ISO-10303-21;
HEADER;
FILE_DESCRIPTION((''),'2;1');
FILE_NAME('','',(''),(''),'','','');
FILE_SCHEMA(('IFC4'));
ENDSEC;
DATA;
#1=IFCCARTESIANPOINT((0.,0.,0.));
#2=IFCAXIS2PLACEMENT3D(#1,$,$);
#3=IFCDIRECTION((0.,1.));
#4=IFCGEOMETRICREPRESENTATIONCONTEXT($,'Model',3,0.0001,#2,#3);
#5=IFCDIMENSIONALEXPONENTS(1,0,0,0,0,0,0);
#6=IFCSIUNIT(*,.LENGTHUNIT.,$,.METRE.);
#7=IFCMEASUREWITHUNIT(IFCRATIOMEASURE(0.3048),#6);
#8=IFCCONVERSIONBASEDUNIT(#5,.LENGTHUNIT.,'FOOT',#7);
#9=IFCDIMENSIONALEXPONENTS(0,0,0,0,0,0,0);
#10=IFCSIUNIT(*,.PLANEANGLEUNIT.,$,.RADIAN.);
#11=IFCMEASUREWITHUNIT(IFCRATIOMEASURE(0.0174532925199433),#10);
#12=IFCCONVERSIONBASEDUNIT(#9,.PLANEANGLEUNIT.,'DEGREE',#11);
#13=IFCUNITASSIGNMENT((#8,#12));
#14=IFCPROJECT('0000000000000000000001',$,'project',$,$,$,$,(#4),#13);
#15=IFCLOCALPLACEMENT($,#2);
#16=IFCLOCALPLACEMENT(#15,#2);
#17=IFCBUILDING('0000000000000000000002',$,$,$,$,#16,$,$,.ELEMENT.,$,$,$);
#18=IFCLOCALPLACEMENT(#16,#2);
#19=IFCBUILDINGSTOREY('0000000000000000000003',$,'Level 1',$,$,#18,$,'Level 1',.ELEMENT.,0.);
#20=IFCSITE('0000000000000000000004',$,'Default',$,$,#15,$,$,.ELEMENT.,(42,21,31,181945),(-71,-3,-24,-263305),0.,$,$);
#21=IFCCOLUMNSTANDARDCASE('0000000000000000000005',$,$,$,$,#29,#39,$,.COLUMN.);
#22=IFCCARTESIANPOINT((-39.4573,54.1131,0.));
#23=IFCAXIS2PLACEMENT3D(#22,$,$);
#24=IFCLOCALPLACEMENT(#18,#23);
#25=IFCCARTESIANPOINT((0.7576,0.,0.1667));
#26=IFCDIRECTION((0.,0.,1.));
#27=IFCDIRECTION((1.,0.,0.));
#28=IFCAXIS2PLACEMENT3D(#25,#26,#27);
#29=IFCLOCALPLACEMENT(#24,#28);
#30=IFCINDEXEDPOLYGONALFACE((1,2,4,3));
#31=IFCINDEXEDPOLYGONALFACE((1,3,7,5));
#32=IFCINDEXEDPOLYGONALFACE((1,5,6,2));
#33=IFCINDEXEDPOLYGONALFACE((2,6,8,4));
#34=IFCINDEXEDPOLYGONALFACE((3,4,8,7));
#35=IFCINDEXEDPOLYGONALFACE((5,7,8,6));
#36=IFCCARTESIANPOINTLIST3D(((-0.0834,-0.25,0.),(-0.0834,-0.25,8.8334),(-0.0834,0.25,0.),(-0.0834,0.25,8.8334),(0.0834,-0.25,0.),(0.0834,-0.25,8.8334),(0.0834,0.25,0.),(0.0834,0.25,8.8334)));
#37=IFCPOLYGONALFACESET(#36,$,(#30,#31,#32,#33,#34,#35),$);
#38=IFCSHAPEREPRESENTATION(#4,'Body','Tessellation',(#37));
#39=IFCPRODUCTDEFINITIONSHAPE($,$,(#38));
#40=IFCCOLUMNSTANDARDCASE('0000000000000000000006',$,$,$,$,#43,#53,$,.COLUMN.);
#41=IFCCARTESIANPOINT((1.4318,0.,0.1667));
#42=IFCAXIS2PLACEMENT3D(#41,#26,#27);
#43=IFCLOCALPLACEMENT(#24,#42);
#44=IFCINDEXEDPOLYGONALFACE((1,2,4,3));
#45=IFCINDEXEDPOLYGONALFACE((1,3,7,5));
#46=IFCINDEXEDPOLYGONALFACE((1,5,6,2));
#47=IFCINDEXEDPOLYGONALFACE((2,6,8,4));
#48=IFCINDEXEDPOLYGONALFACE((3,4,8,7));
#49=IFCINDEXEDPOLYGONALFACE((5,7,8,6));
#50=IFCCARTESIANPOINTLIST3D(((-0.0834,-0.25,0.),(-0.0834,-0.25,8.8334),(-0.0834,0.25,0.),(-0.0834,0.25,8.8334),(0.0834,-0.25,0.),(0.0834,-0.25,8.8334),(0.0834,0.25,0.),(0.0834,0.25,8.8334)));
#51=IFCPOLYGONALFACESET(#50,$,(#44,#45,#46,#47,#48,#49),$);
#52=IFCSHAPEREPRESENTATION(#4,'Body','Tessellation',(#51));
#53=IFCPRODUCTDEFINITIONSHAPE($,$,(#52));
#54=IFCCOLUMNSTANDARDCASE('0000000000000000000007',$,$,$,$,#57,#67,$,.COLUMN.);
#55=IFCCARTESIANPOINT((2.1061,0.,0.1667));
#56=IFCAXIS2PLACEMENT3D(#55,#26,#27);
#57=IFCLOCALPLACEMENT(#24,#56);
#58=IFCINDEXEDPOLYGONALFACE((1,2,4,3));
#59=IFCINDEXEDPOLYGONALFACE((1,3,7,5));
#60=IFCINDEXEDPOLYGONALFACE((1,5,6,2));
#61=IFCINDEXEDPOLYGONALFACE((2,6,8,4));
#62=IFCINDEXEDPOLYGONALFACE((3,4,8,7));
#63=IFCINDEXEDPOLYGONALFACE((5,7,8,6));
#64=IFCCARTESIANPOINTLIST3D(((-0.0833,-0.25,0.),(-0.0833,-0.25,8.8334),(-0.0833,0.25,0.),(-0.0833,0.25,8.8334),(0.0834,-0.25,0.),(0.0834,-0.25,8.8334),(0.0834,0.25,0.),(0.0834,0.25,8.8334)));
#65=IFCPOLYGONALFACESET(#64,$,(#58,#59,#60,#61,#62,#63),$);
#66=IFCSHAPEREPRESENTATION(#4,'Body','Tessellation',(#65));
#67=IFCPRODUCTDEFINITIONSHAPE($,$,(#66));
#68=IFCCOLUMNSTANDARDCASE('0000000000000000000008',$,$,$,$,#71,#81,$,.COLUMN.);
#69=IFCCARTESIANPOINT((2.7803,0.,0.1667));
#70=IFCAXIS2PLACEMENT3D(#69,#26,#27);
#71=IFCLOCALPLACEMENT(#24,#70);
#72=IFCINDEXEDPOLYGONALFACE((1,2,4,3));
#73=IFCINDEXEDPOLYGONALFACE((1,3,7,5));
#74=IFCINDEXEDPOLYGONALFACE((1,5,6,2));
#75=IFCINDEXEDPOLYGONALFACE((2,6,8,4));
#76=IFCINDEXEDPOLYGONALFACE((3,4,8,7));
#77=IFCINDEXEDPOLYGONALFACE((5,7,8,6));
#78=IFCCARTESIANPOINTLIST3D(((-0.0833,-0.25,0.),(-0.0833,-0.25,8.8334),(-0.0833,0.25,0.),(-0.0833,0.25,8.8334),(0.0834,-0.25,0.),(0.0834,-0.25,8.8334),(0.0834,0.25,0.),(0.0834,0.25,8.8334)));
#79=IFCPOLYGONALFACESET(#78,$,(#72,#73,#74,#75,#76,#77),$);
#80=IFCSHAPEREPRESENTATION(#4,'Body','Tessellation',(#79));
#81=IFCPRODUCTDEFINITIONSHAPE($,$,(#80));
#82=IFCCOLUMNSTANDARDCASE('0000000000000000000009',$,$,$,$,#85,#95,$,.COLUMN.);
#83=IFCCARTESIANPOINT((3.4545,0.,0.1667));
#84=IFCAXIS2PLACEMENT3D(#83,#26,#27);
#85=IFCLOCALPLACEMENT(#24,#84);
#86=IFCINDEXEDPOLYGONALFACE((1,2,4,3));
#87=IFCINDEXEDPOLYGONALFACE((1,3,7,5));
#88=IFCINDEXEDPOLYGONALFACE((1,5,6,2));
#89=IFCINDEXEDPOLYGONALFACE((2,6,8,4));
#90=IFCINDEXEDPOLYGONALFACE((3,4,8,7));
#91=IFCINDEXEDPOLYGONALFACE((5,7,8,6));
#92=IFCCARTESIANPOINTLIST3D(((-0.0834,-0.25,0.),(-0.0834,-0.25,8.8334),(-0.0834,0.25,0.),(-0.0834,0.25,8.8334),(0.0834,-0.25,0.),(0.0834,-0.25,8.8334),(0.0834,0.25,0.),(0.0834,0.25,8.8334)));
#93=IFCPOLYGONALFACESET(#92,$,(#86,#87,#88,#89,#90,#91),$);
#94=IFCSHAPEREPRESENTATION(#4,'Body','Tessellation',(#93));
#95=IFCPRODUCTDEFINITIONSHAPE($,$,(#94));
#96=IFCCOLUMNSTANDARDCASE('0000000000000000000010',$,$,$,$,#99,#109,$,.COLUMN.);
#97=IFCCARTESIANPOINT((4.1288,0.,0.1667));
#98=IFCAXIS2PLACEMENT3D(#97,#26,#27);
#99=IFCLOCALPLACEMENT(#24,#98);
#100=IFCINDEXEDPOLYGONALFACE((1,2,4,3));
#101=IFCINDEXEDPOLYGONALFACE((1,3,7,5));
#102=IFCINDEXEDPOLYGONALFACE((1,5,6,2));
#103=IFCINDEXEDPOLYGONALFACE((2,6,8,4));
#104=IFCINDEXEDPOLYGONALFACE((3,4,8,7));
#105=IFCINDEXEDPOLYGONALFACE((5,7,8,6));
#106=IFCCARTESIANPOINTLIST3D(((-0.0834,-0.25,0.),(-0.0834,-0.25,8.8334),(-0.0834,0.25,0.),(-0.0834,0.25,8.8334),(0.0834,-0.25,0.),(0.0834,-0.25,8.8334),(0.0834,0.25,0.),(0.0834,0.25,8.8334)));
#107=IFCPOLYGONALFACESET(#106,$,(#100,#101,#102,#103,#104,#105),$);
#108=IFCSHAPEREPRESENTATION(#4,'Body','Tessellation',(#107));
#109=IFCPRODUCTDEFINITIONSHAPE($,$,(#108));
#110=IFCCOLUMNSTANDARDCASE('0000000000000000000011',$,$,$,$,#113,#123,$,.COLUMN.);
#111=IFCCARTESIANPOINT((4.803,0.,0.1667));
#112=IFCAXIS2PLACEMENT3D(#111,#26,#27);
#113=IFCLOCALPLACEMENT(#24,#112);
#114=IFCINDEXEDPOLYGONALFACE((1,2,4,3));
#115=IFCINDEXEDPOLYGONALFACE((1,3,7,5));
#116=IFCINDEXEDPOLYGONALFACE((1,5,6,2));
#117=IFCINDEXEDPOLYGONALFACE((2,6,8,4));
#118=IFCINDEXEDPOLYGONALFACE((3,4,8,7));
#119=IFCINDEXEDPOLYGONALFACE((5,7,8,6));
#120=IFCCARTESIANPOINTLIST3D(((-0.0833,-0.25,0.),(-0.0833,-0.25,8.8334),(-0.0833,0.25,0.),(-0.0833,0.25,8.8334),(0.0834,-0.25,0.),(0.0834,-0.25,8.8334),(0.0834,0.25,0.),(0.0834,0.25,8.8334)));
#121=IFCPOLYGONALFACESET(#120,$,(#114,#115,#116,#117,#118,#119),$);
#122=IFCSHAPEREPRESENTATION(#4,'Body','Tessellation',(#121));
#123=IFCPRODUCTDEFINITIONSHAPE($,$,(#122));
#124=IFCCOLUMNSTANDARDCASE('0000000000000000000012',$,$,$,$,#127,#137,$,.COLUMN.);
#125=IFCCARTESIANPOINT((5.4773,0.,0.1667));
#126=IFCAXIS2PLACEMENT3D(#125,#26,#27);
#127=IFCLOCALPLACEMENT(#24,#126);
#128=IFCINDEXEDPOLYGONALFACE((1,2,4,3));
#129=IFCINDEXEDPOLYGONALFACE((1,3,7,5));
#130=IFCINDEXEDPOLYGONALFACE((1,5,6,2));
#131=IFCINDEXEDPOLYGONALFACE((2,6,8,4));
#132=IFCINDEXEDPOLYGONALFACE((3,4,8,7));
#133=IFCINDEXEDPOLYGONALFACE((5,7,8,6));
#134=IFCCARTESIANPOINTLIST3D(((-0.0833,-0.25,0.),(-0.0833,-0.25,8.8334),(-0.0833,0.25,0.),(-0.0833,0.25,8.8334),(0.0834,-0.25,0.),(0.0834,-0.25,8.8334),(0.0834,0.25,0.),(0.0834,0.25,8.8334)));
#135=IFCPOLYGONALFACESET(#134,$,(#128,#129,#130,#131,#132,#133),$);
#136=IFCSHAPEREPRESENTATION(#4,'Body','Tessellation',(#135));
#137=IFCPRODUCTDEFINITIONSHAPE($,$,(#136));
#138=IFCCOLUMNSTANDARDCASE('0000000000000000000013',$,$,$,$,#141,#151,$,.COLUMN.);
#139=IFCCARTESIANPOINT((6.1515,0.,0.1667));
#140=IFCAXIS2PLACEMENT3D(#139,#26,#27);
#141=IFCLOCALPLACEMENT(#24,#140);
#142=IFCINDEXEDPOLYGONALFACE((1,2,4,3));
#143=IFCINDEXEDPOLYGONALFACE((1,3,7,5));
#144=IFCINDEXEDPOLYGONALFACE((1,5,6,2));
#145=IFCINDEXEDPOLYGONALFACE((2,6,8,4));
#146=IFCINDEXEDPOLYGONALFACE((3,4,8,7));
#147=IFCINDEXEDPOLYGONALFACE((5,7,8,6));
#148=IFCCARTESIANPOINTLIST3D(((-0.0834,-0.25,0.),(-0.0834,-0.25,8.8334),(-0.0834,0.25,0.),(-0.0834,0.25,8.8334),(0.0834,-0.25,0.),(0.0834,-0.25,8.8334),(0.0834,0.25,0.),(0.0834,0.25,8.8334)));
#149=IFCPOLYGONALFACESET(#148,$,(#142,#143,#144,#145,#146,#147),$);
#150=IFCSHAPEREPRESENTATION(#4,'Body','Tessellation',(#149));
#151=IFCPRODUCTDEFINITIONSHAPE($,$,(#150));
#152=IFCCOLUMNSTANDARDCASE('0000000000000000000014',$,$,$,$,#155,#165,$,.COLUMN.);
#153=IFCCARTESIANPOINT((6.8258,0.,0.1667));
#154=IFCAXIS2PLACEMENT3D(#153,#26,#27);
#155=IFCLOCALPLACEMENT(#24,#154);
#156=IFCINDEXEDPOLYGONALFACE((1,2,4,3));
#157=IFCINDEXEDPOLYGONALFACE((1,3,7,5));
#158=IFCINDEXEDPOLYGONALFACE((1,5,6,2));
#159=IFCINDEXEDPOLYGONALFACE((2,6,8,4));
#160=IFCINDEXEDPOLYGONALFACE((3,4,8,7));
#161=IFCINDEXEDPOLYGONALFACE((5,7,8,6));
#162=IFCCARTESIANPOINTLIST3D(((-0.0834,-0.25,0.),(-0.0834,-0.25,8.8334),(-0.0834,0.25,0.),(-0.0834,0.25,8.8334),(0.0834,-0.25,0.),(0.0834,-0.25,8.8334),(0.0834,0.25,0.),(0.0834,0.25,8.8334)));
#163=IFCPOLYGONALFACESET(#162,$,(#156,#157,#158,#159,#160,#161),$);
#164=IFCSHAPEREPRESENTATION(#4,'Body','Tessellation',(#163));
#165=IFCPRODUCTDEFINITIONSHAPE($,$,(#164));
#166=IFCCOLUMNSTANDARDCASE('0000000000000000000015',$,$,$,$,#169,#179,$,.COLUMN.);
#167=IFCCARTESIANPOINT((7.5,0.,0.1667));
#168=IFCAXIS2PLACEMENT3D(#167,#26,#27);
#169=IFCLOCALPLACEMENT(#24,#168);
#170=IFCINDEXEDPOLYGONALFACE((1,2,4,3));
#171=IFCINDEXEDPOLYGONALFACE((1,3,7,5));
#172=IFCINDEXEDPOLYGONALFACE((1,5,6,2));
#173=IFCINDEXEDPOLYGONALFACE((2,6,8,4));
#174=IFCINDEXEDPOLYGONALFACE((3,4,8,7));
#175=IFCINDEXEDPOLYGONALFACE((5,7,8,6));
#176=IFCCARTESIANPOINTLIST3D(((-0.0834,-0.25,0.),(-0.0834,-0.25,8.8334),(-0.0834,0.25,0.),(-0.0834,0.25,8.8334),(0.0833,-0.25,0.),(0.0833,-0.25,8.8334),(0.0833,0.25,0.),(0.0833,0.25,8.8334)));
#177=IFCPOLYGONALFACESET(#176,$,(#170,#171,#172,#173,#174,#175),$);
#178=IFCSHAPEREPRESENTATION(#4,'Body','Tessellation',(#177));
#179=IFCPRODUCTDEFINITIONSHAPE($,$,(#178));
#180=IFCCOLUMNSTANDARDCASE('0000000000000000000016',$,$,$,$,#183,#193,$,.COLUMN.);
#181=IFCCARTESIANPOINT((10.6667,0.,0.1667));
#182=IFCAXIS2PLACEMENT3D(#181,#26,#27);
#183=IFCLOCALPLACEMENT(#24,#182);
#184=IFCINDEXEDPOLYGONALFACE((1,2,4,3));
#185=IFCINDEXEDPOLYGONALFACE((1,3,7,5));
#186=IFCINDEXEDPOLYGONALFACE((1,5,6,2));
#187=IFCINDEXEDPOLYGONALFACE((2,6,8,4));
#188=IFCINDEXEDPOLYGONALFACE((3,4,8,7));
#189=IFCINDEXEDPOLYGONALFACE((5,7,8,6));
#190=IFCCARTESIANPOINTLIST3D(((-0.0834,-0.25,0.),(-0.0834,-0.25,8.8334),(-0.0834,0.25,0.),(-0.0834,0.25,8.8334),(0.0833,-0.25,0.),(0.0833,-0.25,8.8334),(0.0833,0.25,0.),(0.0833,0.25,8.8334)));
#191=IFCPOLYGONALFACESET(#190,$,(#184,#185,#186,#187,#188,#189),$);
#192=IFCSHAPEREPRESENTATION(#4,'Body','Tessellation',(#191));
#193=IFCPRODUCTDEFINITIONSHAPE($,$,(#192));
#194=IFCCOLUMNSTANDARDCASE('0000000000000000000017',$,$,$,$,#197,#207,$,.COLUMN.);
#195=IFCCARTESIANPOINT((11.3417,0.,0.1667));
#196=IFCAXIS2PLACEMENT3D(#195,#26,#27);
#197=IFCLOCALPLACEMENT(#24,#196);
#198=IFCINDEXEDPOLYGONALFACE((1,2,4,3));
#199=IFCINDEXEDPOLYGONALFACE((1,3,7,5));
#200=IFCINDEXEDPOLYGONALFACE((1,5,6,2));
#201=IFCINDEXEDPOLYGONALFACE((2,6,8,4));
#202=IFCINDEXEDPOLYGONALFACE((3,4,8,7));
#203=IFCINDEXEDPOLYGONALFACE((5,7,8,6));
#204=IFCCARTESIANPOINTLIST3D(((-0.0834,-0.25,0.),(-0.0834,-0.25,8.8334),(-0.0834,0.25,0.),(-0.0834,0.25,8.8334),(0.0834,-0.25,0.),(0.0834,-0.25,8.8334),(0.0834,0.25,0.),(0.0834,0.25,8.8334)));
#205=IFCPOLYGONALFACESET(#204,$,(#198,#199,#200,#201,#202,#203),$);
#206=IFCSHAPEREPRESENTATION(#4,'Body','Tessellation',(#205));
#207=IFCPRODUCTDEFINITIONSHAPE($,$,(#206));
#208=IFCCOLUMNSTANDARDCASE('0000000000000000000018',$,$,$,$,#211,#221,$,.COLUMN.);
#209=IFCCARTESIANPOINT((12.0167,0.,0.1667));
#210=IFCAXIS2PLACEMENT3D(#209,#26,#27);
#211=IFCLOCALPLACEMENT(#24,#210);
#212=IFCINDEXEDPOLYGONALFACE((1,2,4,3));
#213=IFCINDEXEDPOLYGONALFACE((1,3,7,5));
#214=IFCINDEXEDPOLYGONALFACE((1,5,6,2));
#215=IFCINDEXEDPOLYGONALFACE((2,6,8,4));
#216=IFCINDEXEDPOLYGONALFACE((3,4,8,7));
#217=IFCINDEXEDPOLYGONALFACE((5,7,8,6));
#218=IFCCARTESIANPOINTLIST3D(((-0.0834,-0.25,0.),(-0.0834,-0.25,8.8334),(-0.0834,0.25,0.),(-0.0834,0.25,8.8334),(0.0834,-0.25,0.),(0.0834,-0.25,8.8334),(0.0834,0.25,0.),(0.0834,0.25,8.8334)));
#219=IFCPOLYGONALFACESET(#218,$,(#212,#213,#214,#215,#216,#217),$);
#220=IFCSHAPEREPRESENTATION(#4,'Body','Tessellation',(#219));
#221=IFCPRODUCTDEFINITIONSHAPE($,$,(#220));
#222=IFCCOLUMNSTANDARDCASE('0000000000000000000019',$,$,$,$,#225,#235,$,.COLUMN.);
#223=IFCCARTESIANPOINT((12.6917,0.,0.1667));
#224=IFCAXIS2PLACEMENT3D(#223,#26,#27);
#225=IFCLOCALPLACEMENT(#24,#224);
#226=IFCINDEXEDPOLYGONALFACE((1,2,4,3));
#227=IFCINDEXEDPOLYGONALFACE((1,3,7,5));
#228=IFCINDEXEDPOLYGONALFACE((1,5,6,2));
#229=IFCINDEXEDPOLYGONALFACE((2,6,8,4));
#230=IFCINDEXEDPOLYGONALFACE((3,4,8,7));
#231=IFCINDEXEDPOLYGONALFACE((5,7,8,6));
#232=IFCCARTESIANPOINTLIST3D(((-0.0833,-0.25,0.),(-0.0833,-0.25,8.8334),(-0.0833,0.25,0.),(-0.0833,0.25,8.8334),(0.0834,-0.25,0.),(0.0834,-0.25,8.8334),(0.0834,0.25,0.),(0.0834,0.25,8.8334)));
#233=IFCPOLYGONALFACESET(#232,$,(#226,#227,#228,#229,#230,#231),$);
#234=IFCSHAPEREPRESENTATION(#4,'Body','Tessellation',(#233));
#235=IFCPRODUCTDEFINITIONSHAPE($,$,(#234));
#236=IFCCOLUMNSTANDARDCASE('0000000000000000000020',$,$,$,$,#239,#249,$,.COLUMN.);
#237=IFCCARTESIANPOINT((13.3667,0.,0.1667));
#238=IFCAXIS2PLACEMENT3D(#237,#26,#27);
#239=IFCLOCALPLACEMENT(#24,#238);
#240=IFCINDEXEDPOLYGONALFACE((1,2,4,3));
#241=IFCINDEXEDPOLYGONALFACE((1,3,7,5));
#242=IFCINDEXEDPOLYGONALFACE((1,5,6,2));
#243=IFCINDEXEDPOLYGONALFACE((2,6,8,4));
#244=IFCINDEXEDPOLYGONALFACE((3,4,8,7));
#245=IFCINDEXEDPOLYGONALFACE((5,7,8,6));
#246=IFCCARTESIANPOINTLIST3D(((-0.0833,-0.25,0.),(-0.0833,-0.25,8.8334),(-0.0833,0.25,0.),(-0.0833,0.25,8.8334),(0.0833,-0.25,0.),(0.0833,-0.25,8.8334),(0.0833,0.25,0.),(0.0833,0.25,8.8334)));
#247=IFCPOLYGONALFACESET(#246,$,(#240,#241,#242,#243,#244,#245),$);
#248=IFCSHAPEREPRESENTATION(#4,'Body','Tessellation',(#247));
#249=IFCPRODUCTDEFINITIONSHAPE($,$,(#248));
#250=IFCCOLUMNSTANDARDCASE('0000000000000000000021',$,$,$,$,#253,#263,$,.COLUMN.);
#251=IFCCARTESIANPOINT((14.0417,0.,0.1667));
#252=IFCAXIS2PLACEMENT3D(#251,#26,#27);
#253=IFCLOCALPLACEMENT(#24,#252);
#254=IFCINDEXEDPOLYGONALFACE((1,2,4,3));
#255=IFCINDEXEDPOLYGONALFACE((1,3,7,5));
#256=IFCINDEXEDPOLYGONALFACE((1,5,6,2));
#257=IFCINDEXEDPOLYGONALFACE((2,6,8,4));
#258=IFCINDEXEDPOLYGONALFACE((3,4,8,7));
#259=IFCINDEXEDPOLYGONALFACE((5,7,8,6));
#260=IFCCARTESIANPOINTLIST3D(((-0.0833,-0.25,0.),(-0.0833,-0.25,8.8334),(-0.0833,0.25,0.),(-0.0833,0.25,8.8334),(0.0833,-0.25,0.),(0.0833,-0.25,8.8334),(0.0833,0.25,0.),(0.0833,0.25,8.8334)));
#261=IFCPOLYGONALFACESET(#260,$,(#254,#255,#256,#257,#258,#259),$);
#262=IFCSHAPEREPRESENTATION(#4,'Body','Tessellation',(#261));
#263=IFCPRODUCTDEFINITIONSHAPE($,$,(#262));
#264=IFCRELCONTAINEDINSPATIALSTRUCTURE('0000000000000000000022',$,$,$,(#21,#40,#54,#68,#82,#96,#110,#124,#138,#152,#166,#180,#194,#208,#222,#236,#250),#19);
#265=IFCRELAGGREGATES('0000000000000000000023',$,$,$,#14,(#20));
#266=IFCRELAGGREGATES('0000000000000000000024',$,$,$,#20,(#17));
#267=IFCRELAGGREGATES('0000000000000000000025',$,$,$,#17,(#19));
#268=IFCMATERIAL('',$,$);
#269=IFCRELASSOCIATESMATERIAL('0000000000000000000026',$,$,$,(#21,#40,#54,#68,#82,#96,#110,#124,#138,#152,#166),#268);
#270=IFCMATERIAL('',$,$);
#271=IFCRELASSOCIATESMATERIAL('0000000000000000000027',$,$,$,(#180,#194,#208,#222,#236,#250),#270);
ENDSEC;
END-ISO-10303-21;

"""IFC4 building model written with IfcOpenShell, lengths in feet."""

from ifc_helpers import new_model, entity, si_unit, converted_unit, direction, frame, origin, place, context, project, spatial, rectangle, extrude, material, element, save


model = new_model("IFC4")

# Units and contexts
model_context = context("Model", 3, precision=0.0001, world=origin(), true_north=direction((0.0, 1.0)))
ifc_project = project(units=[converted_unit("LENGTHUNIT", "FOOT", entity("IfcRatioMeasure", 0.3048), si_unit("LENGTHUNIT", "METRE"), dimensions=[1, 0, 0, 0, 0, 0, 0]), converted_unit("PLANEANGLEUNIT", "DEGREE", entity("IfcRatioMeasure", 0.0174532925199433), si_unit("PLANEANGLEUNIT", "RADIAN"), dimensions=[0, 0, 0, 0, 0, 0, 0])], contexts=[model_context])

# Site, building, storey
site_placement = place(None, origin())
site = spatial("IfcSite", under=ifc_project, at=site_placement, Name="Default", CompositionType="ELEMENT", RefLatitude=(42, 21, 31, 181945), RefLongitude=(-71, -3, -24, -263305), RefElevation=0.0)
building_placement = place(site_placement, origin())
building = spatial("IfcBuilding", under=site, at=building_placement, CompositionType="ELEMENT")
storey_placement = place(building_placement, origin())
storey = spatial("IfcBuildingStorey", under=building, at=storey_placement, Name="Level 1", LongName="Level 1", CompositionType="ELEMENT", Elevation=0.0)

# Columns
ifc_material_1 = material(Name="")
placement_1 = place(storey_placement, frame((-39.4573, 54.1131, 0.0)))
for number, where, z_axis, x_axis in (
    (1, (0.7576, 0.0, 0.1667), (0.0, 0.0, 1.0), (1.0, 0.0, 0.0)),
    (2, (1.4318, 0.0, 0.1667), (0.0, 0.0, 1.0), (1.0, 0.0, 0.0)),
    (3, (2.1061, 0.0, 0.1667), (0.0, 0.0, 1.0), (1.0, 0.0, 0.0)),
    (4, (2.7803, 0.0, 0.1667), (0.0, 0.0, 1.0), (1.0, 0.0, 0.0)),
    (5, (3.4545, 0.0, 0.1667), (0.0, 0.0, 1.0), (1.0, 0.0, 0.0)),
    (6, (4.1288, 0.0, 0.1667), (0.0, 0.0, 1.0), (1.0, 0.0, 0.0)),
    (7, (4.803, 0.0, 0.1667), (0.0, 0.0, 1.0), (1.0, 0.0, 0.0)),
    (8, (5.4773, 0.0, 0.1667), (0.0, 0.0, 1.0), (1.0, 0.0, 0.0)),
    (9, (6.1515, 0.0, 0.1667), (0.0, 0.0, 1.0), (1.0, 0.0, 0.0)),
    (10, (6.8258, 0.0, 0.1667), (0.0, 0.0, 1.0), (1.0, 0.0, 0.0)),
    (11, (7.5, 0.0, 0.1667), (0.0, 0.0, 1.0), (1.0, 0.0, 0.0)),
):
    element("IfcColumnStandardCase", number, at=place(placement_1, frame(where, z_axis=z_axis, x_axis=x_axis)), inside=storey, material=ifc_material_1, PredefinedType="COLUMN", context=model_context, shape_type="SweptSolid", body=[
        extrude(rectangle(XDim=0.1667, YDim=0.5), origin(), (0.0, 0.0, 1.0), 8.8334),
    ])
ifc_material_2 = material(Name="")
for number, where, z_axis, x_axis in (
    (12, (10.6667, 0.0, 0.1667), (0.0, 0.0, 1.0), (1.0, 0.0, 0.0)),
    (13, (11.3417, 0.0, 0.1667), (0.0, 0.0, 1.0), (1.0, 0.0, 0.0)),
    (14, (12.0167, 0.0, 0.1667), (0.0, 0.0, 1.0), (1.0, 0.0, 0.0)),
    (15, (12.6917, 0.0, 0.1667), (0.0, 0.0, 1.0), (1.0, 0.0, 0.0)),
    (16, (13.3667, 0.0, 0.1667), (0.0, 0.0, 1.0), (1.0, 0.0, 0.0)),
    (17, (14.0417, 0.0, 0.1667), (0.0, 0.0, 1.0), (1.0, 0.0, 0.0)),
):
    element("IfcColumnStandardCase", number, at=place(placement_1, frame(where, z_axis=z_axis, x_axis=x_axis)), inside=storey, material=ifc_material_2, PredefinedType="COLUMN", context=model_context, shape_type="SweptSolid", body=[
        extrude(rectangle(XDim=0.1667, YDim=0.5), origin(), (0.0, 0.0, 1.0), 8.8334),
    ])

save(model, "model.ifc")
